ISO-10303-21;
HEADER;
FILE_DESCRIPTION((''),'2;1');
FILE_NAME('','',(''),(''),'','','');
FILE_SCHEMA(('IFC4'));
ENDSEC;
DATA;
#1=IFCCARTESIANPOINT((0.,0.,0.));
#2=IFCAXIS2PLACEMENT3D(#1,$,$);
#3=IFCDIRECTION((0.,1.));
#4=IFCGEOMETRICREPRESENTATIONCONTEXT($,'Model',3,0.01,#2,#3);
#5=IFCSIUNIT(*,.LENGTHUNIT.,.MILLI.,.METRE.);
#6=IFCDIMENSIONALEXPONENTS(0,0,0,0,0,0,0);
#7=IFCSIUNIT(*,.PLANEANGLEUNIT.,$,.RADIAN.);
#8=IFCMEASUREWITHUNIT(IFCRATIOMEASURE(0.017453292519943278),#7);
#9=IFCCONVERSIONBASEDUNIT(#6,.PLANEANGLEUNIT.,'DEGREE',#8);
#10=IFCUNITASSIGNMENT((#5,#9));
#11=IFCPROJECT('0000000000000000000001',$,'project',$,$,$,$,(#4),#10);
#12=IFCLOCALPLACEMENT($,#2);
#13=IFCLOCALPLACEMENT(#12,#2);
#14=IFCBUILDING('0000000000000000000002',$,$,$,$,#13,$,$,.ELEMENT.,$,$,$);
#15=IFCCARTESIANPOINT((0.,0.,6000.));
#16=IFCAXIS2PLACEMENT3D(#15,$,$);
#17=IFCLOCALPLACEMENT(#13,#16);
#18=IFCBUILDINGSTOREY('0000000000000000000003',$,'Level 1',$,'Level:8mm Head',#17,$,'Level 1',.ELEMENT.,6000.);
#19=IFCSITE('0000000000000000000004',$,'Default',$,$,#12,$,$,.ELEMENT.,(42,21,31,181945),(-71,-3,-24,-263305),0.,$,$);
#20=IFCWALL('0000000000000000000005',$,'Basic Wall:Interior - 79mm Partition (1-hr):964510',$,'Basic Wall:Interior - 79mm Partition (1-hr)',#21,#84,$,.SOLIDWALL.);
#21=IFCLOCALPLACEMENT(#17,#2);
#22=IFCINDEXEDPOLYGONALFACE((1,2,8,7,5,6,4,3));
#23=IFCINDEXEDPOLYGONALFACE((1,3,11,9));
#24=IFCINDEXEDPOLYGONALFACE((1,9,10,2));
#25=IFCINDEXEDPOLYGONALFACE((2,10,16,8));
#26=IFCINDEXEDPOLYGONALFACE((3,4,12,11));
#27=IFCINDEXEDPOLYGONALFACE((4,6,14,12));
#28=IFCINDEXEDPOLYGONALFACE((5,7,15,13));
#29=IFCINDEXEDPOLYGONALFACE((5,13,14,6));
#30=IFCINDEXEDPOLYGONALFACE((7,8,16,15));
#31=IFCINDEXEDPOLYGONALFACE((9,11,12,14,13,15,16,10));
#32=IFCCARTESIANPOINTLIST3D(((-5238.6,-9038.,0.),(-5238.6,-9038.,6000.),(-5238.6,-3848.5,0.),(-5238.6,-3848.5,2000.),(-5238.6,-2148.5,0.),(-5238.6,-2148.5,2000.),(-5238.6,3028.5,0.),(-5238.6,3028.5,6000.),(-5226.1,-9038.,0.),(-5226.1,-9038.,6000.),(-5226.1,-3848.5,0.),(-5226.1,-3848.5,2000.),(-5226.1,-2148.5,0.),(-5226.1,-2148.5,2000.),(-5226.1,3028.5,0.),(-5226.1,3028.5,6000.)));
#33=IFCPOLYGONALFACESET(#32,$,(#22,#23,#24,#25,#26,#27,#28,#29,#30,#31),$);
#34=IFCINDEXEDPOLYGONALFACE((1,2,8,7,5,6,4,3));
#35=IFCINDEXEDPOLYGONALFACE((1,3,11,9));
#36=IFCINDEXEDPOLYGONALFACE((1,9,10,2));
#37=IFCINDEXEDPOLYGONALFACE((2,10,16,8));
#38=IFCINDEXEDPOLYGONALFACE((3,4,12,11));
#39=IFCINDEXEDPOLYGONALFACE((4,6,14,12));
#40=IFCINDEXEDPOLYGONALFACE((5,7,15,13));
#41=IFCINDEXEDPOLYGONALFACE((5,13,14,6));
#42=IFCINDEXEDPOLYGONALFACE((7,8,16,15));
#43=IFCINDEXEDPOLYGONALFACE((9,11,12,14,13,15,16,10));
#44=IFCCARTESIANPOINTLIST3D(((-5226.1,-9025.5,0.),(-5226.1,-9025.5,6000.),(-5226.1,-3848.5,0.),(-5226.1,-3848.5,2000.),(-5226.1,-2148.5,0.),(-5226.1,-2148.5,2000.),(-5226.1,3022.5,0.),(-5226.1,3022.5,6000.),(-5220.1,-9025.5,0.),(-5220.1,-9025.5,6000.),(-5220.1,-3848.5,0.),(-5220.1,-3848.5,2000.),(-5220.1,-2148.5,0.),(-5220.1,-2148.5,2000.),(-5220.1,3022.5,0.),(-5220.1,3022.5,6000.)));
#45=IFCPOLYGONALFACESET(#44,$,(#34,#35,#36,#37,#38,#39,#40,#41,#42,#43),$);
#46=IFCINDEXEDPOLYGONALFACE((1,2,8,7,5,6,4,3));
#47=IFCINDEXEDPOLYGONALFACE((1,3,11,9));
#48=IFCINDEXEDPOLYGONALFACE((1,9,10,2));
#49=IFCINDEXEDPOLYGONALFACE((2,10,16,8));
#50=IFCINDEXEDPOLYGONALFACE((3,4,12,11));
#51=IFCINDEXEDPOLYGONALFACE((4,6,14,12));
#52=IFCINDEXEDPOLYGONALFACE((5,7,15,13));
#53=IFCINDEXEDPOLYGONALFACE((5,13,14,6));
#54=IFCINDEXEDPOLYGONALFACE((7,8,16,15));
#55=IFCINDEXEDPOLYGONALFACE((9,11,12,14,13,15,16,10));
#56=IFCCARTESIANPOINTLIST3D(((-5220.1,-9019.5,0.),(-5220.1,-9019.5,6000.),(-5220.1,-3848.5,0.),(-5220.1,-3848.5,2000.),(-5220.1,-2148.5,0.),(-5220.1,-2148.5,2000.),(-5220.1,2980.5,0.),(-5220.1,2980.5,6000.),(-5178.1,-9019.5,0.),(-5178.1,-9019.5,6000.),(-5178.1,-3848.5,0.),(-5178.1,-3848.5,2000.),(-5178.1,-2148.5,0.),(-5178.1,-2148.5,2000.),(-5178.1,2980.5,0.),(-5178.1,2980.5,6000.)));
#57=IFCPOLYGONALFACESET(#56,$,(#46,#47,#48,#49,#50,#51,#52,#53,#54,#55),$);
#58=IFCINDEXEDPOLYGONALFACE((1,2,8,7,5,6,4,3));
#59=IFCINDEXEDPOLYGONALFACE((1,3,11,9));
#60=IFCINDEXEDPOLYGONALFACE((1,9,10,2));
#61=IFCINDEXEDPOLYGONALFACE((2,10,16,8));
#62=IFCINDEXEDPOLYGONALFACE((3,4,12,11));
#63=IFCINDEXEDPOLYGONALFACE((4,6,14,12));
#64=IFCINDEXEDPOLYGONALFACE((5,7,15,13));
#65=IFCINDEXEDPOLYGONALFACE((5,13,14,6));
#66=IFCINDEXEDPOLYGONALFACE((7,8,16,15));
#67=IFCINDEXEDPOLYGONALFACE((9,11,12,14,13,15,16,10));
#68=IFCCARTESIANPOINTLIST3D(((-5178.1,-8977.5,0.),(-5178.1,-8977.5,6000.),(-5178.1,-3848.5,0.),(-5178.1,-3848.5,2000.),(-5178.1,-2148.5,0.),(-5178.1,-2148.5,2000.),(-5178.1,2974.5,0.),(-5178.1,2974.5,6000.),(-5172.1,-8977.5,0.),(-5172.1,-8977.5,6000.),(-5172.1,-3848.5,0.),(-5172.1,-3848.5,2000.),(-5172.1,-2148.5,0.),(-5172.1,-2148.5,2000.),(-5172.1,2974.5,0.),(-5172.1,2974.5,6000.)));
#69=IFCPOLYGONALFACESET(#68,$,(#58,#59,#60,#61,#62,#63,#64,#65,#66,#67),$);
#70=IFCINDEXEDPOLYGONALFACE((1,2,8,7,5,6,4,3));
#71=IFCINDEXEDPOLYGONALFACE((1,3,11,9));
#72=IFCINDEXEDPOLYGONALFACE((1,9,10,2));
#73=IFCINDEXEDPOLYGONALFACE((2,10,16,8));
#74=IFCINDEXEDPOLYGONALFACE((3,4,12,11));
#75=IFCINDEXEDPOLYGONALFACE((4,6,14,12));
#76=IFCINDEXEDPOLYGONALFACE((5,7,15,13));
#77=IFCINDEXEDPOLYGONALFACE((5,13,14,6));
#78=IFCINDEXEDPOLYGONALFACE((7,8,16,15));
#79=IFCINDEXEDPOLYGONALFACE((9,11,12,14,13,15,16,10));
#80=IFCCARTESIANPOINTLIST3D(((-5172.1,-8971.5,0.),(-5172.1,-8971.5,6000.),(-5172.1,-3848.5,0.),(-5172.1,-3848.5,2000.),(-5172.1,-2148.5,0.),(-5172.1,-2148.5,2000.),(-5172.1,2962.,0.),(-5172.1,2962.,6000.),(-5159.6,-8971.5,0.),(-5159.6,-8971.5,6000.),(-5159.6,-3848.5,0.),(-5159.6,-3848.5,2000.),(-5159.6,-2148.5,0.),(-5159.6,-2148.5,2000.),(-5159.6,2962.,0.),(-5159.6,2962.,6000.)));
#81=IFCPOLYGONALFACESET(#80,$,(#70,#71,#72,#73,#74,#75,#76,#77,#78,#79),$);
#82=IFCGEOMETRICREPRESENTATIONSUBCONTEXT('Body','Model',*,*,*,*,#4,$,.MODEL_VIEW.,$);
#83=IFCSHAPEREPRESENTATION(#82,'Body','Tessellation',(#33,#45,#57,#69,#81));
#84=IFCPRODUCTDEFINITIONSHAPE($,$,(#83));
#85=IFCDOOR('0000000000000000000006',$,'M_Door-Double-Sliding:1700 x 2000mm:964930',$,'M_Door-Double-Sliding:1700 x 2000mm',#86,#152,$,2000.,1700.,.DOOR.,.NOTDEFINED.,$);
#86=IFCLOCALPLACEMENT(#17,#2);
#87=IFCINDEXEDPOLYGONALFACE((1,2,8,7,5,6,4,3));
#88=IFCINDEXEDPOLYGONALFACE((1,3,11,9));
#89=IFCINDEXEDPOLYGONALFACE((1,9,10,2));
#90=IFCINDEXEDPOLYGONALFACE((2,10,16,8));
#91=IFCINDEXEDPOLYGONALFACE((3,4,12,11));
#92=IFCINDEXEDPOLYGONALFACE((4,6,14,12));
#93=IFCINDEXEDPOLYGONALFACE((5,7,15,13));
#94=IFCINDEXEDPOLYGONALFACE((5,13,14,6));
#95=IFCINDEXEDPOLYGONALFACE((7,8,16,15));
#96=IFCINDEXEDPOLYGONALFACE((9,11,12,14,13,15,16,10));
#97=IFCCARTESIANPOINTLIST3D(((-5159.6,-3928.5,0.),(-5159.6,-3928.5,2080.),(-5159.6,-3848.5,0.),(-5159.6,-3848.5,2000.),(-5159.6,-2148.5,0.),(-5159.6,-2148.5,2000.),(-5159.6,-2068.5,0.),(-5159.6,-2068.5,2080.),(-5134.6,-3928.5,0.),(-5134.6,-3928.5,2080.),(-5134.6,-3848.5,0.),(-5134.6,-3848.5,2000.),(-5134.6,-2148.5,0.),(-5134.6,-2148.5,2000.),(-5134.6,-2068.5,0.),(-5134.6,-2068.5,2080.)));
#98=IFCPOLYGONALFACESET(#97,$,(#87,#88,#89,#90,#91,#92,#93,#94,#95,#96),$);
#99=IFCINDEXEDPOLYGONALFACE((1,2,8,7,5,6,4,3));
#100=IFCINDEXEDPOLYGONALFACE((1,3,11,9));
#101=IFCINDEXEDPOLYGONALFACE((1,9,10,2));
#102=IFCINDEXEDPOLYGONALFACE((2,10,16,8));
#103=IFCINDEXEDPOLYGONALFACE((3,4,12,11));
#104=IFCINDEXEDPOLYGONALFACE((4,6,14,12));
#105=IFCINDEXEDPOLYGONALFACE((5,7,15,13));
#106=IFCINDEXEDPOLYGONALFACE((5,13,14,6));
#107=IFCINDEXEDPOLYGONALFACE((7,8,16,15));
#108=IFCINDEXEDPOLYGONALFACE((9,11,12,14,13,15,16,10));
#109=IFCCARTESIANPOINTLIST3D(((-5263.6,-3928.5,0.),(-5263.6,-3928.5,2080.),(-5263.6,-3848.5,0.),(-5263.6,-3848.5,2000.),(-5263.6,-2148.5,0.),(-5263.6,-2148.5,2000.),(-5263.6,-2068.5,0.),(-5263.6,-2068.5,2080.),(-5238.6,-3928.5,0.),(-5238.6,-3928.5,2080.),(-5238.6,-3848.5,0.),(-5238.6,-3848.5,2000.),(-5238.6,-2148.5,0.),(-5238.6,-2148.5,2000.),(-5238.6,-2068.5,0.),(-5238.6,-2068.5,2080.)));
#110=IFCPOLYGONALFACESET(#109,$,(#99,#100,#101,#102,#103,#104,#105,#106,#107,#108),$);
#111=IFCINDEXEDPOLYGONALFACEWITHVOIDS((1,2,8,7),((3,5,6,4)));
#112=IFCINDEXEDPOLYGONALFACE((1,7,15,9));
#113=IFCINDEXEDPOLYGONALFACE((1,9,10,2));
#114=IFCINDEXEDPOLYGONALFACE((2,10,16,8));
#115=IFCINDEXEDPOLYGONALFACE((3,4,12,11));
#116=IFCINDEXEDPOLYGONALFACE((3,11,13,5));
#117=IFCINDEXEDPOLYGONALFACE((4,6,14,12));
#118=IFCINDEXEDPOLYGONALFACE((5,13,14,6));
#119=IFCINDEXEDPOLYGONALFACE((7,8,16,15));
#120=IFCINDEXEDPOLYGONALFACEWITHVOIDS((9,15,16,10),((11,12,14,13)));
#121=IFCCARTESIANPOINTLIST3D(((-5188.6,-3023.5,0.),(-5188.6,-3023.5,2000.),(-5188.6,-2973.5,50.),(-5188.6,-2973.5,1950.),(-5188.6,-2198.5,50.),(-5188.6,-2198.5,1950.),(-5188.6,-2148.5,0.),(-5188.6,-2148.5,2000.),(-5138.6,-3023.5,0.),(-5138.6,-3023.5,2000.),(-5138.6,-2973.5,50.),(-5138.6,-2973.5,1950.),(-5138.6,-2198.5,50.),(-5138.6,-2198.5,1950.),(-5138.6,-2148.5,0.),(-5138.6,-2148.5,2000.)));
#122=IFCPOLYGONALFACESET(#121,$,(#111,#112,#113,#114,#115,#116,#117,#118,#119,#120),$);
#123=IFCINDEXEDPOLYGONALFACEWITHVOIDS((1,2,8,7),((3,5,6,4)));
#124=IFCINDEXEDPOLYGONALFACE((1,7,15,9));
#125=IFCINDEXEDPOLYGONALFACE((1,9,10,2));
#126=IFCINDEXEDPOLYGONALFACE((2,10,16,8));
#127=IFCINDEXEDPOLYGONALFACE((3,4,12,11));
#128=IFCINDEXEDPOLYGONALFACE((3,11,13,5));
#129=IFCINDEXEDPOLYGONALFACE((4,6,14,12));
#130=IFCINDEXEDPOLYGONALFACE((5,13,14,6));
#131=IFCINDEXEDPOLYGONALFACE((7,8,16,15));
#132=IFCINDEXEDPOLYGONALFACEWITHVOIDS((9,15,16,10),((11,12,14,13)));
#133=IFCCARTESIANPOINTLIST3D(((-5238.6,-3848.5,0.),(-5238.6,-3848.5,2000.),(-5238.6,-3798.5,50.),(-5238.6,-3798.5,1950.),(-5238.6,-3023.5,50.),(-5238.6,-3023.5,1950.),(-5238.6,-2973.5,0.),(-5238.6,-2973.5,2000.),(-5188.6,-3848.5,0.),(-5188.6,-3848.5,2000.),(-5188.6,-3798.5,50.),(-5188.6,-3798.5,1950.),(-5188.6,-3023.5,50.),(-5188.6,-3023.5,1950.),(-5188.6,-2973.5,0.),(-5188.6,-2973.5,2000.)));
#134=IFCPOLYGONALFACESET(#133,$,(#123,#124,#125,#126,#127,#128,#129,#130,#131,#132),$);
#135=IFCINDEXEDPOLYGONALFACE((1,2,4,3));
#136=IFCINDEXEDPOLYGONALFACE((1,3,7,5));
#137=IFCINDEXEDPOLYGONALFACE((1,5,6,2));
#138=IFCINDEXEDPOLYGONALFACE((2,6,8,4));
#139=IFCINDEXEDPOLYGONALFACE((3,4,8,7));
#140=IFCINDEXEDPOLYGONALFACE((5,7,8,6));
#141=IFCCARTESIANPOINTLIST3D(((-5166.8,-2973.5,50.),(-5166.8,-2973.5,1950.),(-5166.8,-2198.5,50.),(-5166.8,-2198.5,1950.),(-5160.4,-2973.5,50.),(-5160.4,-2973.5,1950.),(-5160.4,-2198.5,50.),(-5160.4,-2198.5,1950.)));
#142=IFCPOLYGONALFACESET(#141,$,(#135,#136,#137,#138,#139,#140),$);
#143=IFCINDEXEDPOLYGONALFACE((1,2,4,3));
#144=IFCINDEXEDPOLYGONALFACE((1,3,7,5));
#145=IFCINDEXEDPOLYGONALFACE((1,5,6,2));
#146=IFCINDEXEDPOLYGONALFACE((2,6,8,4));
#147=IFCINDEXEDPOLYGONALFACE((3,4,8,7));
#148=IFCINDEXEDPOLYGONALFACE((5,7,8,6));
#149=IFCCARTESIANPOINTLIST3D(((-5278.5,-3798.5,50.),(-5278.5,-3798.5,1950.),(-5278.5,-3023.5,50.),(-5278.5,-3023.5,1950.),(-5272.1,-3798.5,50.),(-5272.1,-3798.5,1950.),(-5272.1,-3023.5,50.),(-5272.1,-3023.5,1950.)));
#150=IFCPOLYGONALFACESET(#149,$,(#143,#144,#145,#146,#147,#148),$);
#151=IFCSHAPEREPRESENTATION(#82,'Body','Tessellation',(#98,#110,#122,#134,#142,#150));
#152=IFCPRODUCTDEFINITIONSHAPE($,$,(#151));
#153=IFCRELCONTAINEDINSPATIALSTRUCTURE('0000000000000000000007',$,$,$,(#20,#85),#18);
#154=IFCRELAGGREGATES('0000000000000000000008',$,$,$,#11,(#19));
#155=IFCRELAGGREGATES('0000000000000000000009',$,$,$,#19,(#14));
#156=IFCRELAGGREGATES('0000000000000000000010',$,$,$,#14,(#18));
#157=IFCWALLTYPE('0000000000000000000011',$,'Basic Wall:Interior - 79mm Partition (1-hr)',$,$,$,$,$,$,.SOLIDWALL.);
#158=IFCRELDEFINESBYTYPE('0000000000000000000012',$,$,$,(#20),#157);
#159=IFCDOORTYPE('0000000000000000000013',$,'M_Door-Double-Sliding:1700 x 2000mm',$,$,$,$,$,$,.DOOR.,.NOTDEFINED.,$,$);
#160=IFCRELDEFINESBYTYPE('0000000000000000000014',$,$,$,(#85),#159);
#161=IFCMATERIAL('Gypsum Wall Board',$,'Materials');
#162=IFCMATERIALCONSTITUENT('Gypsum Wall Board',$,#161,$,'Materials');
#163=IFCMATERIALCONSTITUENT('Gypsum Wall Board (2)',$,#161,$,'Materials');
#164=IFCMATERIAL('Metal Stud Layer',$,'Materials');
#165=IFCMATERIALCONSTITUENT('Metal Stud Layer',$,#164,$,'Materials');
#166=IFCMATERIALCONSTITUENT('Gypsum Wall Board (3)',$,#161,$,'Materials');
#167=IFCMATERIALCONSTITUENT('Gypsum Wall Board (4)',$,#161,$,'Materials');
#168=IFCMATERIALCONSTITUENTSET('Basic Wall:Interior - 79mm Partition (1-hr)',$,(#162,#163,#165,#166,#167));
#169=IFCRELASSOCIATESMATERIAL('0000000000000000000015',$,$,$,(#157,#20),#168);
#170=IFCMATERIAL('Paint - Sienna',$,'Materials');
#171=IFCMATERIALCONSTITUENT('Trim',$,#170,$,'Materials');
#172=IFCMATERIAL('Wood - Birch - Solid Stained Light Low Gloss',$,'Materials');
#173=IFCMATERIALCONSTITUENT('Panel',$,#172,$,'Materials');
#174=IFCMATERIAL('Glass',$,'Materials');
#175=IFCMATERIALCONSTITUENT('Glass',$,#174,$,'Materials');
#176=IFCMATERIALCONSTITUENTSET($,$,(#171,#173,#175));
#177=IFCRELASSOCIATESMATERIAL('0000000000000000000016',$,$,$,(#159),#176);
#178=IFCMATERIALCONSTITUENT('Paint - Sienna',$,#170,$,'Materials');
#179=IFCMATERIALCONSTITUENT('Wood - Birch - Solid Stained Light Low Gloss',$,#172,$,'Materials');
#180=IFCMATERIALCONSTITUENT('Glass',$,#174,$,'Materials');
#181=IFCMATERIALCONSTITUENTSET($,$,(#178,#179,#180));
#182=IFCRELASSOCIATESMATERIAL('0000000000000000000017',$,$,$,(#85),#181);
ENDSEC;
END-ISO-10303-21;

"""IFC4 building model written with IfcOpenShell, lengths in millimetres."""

from ifc_helpers import new_model, entity, si_unit, converted_unit, direction, frame, origin, place, context, subcontext, project, spatial, indexed_curve, outline, extrude, source, transform, mapped, material, constituent, constituent_set, type_object, type_shapes, element, fill, save


model = new_model("IFC4")

# Units and contexts
model_context = context("Model", 3, precision=0.01, world=origin(), true_north=direction((0.0, 1.0)))
body_context = subcontext(model_context, "Body", "Model", "MODEL_VIEW")
ifc_project = project(units=[si_unit("LENGTHUNIT", "METRE", prefix="MILLI"), converted_unit("PLANEANGLEUNIT", "DEGREE", entity("IfcRatioMeasure", 0.017453292519943278), si_unit("PLANEANGLEUNIT", "RADIAN"), dimensions=[0, 0, 0, 0, 0, 0, 0])], contexts=[model_context])

# Site, building, storey
site_placement = place(None, origin())
site = spatial("IfcSite", under=ifc_project, at=site_placement, Name="Default", CompositionType="ELEMENT", RefLatitude=(42, 21, 31, 181945), RefLongitude=(-71, -3, -24, -263305), RefElevation=0.0)
building_placement = place(site_placement, origin())
building = spatial("IfcBuilding", under=site, at=building_placement, CompositionType="ELEMENT")
storey_placement = place(building_placement, frame((0.0, 0.0, 6000.0)))
storey = spatial("IfcBuildingStorey", under=building, at=storey_placement, Name="Level 1", ObjectType="Level:8mm Head", LongName="Level 1", CompositionType="ELEMENT", Elevation=6000.0)

# Shared definitions
ifc_material_1 = material(Name="Gypsum Wall Board", Category="Materials")
ifc_constituent_1 = constituent(ifc_material_1, Name="Gypsum Wall Board", Category="Materials")
ifc_constituent_2 = constituent(ifc_material_1, Name="Gypsum Wall Board (2)", Category="Materials")
ifc_material_2 = material(Name="Metal Stud Layer", Category="Materials")
ifc_constituent_3 = constituent(ifc_material_2, Name="Metal Stud Layer", Category="Materials")
ifc_constituent_4 = constituent(ifc_material_1, Name="Gypsum Wall Board (3)", Category="Materials")
ifc_constituent_5 = constituent(ifc_material_1, Name="Gypsum Wall Board (4)", Category="Materials")
ifc_constituent_set_1 = constituent_set(constituents=[ifc_constituent_1, ifc_constituent_2, ifc_constituent_3, ifc_constituent_4, ifc_constituent_5], Name="Basic Wall:Interior - 79mm Partition (1-hr)")
wall_type = type_object("IfcWallType", Name="Basic Wall:Interior - 79mm Partition (1-hr)", PredefinedType="SOLIDWALL", material=ifc_constituent_set_1)

# Wall, opening, door
ifc_material_3 = material(Name="Paint - Sienna", Category="Materials")
ifc_material_4 = material(Name="Wood - Birch - Solid Stained Light Low Gloss", Category="Materials")
ifc_material_5 = material(Name="Glass", Category="Materials")
ifc_constituent_6 = constituent(ifc_material_3, Name="Trim", Category="Materials")
ifc_constituent_7 = constituent(ifc_material_4, Name="Panel", Category="Materials")
ifc_constituent_8 = constituent(ifc_material_5, Name="Glass", Category="Materials")
ifc_constituent_set_2 = constituent_set(constituents=[ifc_constituent_6, ifc_constituent_7, ifc_constituent_8])
door_type = type_object("IfcDoorType", Name="M_Door-Double-Sliding:1700 x 2000mm", OperationType="NOTDEFINED", PredefinedType="DOOR", material=ifc_constituent_set_2)
shared_shape_1 = source(origin(), body_context, "Body", "SweptSolid", [
    extrude(outline(indexed_curve([(-1020.0, -930.0), (1060.0, -930.0), (1060.0, 930.0), (-1020.0, 930.0), (-1020.0, 850.0), (980.0, 850.0), (980.0, -850.0), (-1020.0, -850.0), (-1020.0, -930.0)], self_intersect=False)), frame((850.0, -25.0, 1020.0), z_axis=(0.0, 1.0, 0.0), x_axis=(0.0, 0.0, 1.0)), (0.0, 0.0, 1.0), 25.0),
    extrude(outline(indexed_curve([(-930.0, -1020.0), (-850.0, -1020.0), (-850.0, 980.0), (850.0, 980.0), (850.0, -1020.0), (930.0, -1020.0), (930.0, 1060.0), (-930.0, 1060.0), (-930.0, -1020.0)], self_intersect=False)), frame((850.0, 79.0, 1020.0), z_axis=(0.0, 1.0, 0.0), x_axis=(-1.0, 0.0, 0.0)), (0.0, 0.0, 1.0), 25.0),
    extrude(outline(indexed_curve([(-437.5, -1000.0), (437.5, -1000.0), (437.5, 1000.0), (-437.5, 1000.0), (-437.5, -1000.0)], self_intersect=False), holes=[indexed_curve([(-387.5, -950.0), (-387.5, 950.0), (387.5, 950.0), (387.5, -950.0), (-387.5, -950.0)], self_intersect=False)]), frame((1262.5, -21.0, 1000.0), z_axis=(0.0, 1.0, 0.0), x_axis=(1.0, 0.0, 0.0)), (0.0, 0.0, 1.0), 50.0),
    extrude(outline(indexed_curve([(-1000.0, -437.5), (1000.0, -437.5), (1000.0, 437.5), (-1000.0, 437.5), (-1000.0, -437.5)], self_intersect=False), holes=[indexed_curve([(-950.0, -387.5), (-950.0, 387.5), (950.0, 387.5), (950.0, -387.5), (-950.0, -387.5)], self_intersect=False)]), frame((437.5, 29.0, 1000.0), z_axis=(0.0, 1.0, 0.0), x_axis=(0.0, 0.0, -1.0)), (0.0, 0.0, 1.0), 50.0),
    extrude(outline(indexed_curve([(-3.2, -387.5), (3.2, -387.5), (3.2, 387.5), (-3.2, 387.5), (-3.2, -387.5)], self_intersect=False)), frame((1262.5, 4.0, 50.0), z_axis=(0.0, 0.0, 1.0), x_axis=(0.0, -1.0, 0.0)), (0.0, 0.0, 1.0), 1900.0),
    extrude(outline(indexed_curve([(-3.2, -387.5), (3.2, -387.5), (3.2, 387.5), (-3.2, 387.5), (-3.2, -387.5)], self_intersect=False)), frame((437.5, 115.7, 50.0), z_axis=(0.0, 0.0, 1.0), x_axis=(0.0, 1.0, 0.0)), (0.0, 0.0, 1.0), 1900.0),
])
type_shapes(door_type, [shared_shape_1])
wall_1_placement = place(storey_placement, frame((-5199.1, 2962.0, 0.0), z_axis=(0.0, 0.0, 1.0), x_axis=(0.0, -1.0, 0.0)))
wall_1 = element("IfcWall", 1, at=wall_1_placement, inside=storey, type_object=wall_type, material=ifc_constituent_set_1, Name="Basic Wall:Interior - 79mm Partition (1-hr):964510", ObjectType="Basic Wall:Interior - 79mm Partition (1-hr)", PredefinedType="SOLIDWALL", context=body_context, shape_type="SweptSolid", body=[
    extrude(outline(indexed_curve([(-2000.0, -6030.1), (4000.0, -6030.1), (4000.0, 6036.4), (-2000.0, 6036.4), (-2000.0, 846.9), (0.0, 846.9), (0.0, -853.1), (-2000.0, -853.1), (-2000.0, -6030.1)], self_intersect=False)), frame((5963.6, -39.5, 2000.0), z_axis=(0.0, 1.0, 0.0), x_axis=(0.0, 0.0, 1.0)), (0.0, 0.0, 1.0), 12.5),
    extrude(outline(indexed_curve([(-2000.0, -6022.5), (4000.0, -6022.5), (4000.0, 6025.5), (-2000.0, 6025.5), (-2000.0, 848.5), (0.0, 848.5), (0.0, -851.5), (-2000.0, -851.5), (-2000.0, -6022.5)], self_intersect=False)), frame((5962.0, -27.0, 2000.0), z_axis=(0.0, 1.0, 0.0), x_axis=(0.0, 0.0, 1.0)), (0.0, 0.0, 1.0), 6.0),
    extrude(outline(indexed_curve([(-2000.0, -5989.5), (4000.0, -5989.5), (4000.0, 6010.5), (-2000.0, 6010.5), (-2000.0, 839.5), (0.0, 839.5), (0.0, -860.5), (-2000.0, -860.5), (-2000.0, -5989.5)], self_intersect=False)), frame((5971.0, -21.0, 2000.0), z_axis=(0.0, 1.0, 0.0), x_axis=(0.0, 0.0, 1.0)), (0.0, 0.0, 1.0), 42.0),
    extrude(outline(indexed_curve([(-2000.0, -5974.5), (4000.0, -5974.5), (4000.0, 5977.5), (-2000.0, 5977.5), (-2000.0, 848.5), (0.0, 848.5), (0.0, -851.5), (-2000.0, -851.5), (-2000.0, -5974.5)], self_intersect=False)), frame((5962.0, 21.0, 2000.0), z_axis=(0.0, 1.0, 0.0), x_axis=(0.0, 0.0, 1.0)), (0.0, 0.0, 1.0), 6.0),
    extrude(outline(indexed_curve([(-2000.0, -5963.6), (4000.0, -5963.6), (4000.0, 5969.9), (-2000.0, 5969.9), (-2000.0, 846.9), (0.0, 846.9), (0.0, -853.1), (-2000.0, -853.1), (-2000.0, -5963.6)], self_intersect=False)), frame((5963.6, 27.0, 2000.0), z_axis=(0.0, 1.0, 0.0), x_axis=(0.0, 0.0, 1.0)), (0.0, 0.0, 1.0), 12.5),
])
opening_1_placement = place(wall_1_placement, frame((6810.5, 39.5, 0.0)))
opening_1 = element("IfcOpeningElement", 2, at=opening_1_placement, cuts=wall_1, PredefinedType="OPENING", context=body_context, shape_type="SweptSolid", body=[
    extrude(outline(indexed_curve([(2000.0, 0.0), (2000.0, 1700.0), (0.0, 1700.0), (0.0, 0.0), (2000.0, 0.0)], self_intersect=False)), frame((0.0, 0.0, 0.0), z_axis=(0.0, -1.0, 0.0), x_axis=(0.0, 0.0, 1.0)), (0.0, 0.0, 1.0), 79.0),
])
ifc_constituent_9 = constituent(ifc_material_3, Name="Paint - Sienna", Category="Materials")
ifc_constituent_10 = constituent(ifc_material_4, Name="Wood - Birch - Solid Stained Light Low Gloss", Category="Materials")
ifc_constituent_11 = constituent(ifc_material_5, Name="Glass", Category="Materials")
ifc_constituent_set_3 = constituent_set(constituents=[ifc_constituent_9, ifc_constituent_10, ifc_constituent_11])
door_1_placement = place(opening_1_placement, frame((0.0, 0.0, 0.0), z_axis=(0.0, 0.0, 1.0), x_axis=(-1.0, 0.0, 0.0)))
door_1 = element("IfcDoor", 3, at=door_1_placement, inside=storey, type_object=door_type, material=ifc_constituent_set_3, Name="M_Door-Double-Sliding:1700 x 2000mm:964930", ObjectType="M_Door-Double-Sliding:1700 x 2000mm", OperationType="NOTDEFINED", OverallHeight=2000.0, OverallWidth=1700.0, PredefinedType="DOOR", context=body_context, shape_type="MappedRepresentation", body=[
    mapped(shared_shape_1, transform((0.0, 0.0, 0.0), scale=1.0)),
])
fill(opening_1, door_1)

save(model, "model.ifc")
